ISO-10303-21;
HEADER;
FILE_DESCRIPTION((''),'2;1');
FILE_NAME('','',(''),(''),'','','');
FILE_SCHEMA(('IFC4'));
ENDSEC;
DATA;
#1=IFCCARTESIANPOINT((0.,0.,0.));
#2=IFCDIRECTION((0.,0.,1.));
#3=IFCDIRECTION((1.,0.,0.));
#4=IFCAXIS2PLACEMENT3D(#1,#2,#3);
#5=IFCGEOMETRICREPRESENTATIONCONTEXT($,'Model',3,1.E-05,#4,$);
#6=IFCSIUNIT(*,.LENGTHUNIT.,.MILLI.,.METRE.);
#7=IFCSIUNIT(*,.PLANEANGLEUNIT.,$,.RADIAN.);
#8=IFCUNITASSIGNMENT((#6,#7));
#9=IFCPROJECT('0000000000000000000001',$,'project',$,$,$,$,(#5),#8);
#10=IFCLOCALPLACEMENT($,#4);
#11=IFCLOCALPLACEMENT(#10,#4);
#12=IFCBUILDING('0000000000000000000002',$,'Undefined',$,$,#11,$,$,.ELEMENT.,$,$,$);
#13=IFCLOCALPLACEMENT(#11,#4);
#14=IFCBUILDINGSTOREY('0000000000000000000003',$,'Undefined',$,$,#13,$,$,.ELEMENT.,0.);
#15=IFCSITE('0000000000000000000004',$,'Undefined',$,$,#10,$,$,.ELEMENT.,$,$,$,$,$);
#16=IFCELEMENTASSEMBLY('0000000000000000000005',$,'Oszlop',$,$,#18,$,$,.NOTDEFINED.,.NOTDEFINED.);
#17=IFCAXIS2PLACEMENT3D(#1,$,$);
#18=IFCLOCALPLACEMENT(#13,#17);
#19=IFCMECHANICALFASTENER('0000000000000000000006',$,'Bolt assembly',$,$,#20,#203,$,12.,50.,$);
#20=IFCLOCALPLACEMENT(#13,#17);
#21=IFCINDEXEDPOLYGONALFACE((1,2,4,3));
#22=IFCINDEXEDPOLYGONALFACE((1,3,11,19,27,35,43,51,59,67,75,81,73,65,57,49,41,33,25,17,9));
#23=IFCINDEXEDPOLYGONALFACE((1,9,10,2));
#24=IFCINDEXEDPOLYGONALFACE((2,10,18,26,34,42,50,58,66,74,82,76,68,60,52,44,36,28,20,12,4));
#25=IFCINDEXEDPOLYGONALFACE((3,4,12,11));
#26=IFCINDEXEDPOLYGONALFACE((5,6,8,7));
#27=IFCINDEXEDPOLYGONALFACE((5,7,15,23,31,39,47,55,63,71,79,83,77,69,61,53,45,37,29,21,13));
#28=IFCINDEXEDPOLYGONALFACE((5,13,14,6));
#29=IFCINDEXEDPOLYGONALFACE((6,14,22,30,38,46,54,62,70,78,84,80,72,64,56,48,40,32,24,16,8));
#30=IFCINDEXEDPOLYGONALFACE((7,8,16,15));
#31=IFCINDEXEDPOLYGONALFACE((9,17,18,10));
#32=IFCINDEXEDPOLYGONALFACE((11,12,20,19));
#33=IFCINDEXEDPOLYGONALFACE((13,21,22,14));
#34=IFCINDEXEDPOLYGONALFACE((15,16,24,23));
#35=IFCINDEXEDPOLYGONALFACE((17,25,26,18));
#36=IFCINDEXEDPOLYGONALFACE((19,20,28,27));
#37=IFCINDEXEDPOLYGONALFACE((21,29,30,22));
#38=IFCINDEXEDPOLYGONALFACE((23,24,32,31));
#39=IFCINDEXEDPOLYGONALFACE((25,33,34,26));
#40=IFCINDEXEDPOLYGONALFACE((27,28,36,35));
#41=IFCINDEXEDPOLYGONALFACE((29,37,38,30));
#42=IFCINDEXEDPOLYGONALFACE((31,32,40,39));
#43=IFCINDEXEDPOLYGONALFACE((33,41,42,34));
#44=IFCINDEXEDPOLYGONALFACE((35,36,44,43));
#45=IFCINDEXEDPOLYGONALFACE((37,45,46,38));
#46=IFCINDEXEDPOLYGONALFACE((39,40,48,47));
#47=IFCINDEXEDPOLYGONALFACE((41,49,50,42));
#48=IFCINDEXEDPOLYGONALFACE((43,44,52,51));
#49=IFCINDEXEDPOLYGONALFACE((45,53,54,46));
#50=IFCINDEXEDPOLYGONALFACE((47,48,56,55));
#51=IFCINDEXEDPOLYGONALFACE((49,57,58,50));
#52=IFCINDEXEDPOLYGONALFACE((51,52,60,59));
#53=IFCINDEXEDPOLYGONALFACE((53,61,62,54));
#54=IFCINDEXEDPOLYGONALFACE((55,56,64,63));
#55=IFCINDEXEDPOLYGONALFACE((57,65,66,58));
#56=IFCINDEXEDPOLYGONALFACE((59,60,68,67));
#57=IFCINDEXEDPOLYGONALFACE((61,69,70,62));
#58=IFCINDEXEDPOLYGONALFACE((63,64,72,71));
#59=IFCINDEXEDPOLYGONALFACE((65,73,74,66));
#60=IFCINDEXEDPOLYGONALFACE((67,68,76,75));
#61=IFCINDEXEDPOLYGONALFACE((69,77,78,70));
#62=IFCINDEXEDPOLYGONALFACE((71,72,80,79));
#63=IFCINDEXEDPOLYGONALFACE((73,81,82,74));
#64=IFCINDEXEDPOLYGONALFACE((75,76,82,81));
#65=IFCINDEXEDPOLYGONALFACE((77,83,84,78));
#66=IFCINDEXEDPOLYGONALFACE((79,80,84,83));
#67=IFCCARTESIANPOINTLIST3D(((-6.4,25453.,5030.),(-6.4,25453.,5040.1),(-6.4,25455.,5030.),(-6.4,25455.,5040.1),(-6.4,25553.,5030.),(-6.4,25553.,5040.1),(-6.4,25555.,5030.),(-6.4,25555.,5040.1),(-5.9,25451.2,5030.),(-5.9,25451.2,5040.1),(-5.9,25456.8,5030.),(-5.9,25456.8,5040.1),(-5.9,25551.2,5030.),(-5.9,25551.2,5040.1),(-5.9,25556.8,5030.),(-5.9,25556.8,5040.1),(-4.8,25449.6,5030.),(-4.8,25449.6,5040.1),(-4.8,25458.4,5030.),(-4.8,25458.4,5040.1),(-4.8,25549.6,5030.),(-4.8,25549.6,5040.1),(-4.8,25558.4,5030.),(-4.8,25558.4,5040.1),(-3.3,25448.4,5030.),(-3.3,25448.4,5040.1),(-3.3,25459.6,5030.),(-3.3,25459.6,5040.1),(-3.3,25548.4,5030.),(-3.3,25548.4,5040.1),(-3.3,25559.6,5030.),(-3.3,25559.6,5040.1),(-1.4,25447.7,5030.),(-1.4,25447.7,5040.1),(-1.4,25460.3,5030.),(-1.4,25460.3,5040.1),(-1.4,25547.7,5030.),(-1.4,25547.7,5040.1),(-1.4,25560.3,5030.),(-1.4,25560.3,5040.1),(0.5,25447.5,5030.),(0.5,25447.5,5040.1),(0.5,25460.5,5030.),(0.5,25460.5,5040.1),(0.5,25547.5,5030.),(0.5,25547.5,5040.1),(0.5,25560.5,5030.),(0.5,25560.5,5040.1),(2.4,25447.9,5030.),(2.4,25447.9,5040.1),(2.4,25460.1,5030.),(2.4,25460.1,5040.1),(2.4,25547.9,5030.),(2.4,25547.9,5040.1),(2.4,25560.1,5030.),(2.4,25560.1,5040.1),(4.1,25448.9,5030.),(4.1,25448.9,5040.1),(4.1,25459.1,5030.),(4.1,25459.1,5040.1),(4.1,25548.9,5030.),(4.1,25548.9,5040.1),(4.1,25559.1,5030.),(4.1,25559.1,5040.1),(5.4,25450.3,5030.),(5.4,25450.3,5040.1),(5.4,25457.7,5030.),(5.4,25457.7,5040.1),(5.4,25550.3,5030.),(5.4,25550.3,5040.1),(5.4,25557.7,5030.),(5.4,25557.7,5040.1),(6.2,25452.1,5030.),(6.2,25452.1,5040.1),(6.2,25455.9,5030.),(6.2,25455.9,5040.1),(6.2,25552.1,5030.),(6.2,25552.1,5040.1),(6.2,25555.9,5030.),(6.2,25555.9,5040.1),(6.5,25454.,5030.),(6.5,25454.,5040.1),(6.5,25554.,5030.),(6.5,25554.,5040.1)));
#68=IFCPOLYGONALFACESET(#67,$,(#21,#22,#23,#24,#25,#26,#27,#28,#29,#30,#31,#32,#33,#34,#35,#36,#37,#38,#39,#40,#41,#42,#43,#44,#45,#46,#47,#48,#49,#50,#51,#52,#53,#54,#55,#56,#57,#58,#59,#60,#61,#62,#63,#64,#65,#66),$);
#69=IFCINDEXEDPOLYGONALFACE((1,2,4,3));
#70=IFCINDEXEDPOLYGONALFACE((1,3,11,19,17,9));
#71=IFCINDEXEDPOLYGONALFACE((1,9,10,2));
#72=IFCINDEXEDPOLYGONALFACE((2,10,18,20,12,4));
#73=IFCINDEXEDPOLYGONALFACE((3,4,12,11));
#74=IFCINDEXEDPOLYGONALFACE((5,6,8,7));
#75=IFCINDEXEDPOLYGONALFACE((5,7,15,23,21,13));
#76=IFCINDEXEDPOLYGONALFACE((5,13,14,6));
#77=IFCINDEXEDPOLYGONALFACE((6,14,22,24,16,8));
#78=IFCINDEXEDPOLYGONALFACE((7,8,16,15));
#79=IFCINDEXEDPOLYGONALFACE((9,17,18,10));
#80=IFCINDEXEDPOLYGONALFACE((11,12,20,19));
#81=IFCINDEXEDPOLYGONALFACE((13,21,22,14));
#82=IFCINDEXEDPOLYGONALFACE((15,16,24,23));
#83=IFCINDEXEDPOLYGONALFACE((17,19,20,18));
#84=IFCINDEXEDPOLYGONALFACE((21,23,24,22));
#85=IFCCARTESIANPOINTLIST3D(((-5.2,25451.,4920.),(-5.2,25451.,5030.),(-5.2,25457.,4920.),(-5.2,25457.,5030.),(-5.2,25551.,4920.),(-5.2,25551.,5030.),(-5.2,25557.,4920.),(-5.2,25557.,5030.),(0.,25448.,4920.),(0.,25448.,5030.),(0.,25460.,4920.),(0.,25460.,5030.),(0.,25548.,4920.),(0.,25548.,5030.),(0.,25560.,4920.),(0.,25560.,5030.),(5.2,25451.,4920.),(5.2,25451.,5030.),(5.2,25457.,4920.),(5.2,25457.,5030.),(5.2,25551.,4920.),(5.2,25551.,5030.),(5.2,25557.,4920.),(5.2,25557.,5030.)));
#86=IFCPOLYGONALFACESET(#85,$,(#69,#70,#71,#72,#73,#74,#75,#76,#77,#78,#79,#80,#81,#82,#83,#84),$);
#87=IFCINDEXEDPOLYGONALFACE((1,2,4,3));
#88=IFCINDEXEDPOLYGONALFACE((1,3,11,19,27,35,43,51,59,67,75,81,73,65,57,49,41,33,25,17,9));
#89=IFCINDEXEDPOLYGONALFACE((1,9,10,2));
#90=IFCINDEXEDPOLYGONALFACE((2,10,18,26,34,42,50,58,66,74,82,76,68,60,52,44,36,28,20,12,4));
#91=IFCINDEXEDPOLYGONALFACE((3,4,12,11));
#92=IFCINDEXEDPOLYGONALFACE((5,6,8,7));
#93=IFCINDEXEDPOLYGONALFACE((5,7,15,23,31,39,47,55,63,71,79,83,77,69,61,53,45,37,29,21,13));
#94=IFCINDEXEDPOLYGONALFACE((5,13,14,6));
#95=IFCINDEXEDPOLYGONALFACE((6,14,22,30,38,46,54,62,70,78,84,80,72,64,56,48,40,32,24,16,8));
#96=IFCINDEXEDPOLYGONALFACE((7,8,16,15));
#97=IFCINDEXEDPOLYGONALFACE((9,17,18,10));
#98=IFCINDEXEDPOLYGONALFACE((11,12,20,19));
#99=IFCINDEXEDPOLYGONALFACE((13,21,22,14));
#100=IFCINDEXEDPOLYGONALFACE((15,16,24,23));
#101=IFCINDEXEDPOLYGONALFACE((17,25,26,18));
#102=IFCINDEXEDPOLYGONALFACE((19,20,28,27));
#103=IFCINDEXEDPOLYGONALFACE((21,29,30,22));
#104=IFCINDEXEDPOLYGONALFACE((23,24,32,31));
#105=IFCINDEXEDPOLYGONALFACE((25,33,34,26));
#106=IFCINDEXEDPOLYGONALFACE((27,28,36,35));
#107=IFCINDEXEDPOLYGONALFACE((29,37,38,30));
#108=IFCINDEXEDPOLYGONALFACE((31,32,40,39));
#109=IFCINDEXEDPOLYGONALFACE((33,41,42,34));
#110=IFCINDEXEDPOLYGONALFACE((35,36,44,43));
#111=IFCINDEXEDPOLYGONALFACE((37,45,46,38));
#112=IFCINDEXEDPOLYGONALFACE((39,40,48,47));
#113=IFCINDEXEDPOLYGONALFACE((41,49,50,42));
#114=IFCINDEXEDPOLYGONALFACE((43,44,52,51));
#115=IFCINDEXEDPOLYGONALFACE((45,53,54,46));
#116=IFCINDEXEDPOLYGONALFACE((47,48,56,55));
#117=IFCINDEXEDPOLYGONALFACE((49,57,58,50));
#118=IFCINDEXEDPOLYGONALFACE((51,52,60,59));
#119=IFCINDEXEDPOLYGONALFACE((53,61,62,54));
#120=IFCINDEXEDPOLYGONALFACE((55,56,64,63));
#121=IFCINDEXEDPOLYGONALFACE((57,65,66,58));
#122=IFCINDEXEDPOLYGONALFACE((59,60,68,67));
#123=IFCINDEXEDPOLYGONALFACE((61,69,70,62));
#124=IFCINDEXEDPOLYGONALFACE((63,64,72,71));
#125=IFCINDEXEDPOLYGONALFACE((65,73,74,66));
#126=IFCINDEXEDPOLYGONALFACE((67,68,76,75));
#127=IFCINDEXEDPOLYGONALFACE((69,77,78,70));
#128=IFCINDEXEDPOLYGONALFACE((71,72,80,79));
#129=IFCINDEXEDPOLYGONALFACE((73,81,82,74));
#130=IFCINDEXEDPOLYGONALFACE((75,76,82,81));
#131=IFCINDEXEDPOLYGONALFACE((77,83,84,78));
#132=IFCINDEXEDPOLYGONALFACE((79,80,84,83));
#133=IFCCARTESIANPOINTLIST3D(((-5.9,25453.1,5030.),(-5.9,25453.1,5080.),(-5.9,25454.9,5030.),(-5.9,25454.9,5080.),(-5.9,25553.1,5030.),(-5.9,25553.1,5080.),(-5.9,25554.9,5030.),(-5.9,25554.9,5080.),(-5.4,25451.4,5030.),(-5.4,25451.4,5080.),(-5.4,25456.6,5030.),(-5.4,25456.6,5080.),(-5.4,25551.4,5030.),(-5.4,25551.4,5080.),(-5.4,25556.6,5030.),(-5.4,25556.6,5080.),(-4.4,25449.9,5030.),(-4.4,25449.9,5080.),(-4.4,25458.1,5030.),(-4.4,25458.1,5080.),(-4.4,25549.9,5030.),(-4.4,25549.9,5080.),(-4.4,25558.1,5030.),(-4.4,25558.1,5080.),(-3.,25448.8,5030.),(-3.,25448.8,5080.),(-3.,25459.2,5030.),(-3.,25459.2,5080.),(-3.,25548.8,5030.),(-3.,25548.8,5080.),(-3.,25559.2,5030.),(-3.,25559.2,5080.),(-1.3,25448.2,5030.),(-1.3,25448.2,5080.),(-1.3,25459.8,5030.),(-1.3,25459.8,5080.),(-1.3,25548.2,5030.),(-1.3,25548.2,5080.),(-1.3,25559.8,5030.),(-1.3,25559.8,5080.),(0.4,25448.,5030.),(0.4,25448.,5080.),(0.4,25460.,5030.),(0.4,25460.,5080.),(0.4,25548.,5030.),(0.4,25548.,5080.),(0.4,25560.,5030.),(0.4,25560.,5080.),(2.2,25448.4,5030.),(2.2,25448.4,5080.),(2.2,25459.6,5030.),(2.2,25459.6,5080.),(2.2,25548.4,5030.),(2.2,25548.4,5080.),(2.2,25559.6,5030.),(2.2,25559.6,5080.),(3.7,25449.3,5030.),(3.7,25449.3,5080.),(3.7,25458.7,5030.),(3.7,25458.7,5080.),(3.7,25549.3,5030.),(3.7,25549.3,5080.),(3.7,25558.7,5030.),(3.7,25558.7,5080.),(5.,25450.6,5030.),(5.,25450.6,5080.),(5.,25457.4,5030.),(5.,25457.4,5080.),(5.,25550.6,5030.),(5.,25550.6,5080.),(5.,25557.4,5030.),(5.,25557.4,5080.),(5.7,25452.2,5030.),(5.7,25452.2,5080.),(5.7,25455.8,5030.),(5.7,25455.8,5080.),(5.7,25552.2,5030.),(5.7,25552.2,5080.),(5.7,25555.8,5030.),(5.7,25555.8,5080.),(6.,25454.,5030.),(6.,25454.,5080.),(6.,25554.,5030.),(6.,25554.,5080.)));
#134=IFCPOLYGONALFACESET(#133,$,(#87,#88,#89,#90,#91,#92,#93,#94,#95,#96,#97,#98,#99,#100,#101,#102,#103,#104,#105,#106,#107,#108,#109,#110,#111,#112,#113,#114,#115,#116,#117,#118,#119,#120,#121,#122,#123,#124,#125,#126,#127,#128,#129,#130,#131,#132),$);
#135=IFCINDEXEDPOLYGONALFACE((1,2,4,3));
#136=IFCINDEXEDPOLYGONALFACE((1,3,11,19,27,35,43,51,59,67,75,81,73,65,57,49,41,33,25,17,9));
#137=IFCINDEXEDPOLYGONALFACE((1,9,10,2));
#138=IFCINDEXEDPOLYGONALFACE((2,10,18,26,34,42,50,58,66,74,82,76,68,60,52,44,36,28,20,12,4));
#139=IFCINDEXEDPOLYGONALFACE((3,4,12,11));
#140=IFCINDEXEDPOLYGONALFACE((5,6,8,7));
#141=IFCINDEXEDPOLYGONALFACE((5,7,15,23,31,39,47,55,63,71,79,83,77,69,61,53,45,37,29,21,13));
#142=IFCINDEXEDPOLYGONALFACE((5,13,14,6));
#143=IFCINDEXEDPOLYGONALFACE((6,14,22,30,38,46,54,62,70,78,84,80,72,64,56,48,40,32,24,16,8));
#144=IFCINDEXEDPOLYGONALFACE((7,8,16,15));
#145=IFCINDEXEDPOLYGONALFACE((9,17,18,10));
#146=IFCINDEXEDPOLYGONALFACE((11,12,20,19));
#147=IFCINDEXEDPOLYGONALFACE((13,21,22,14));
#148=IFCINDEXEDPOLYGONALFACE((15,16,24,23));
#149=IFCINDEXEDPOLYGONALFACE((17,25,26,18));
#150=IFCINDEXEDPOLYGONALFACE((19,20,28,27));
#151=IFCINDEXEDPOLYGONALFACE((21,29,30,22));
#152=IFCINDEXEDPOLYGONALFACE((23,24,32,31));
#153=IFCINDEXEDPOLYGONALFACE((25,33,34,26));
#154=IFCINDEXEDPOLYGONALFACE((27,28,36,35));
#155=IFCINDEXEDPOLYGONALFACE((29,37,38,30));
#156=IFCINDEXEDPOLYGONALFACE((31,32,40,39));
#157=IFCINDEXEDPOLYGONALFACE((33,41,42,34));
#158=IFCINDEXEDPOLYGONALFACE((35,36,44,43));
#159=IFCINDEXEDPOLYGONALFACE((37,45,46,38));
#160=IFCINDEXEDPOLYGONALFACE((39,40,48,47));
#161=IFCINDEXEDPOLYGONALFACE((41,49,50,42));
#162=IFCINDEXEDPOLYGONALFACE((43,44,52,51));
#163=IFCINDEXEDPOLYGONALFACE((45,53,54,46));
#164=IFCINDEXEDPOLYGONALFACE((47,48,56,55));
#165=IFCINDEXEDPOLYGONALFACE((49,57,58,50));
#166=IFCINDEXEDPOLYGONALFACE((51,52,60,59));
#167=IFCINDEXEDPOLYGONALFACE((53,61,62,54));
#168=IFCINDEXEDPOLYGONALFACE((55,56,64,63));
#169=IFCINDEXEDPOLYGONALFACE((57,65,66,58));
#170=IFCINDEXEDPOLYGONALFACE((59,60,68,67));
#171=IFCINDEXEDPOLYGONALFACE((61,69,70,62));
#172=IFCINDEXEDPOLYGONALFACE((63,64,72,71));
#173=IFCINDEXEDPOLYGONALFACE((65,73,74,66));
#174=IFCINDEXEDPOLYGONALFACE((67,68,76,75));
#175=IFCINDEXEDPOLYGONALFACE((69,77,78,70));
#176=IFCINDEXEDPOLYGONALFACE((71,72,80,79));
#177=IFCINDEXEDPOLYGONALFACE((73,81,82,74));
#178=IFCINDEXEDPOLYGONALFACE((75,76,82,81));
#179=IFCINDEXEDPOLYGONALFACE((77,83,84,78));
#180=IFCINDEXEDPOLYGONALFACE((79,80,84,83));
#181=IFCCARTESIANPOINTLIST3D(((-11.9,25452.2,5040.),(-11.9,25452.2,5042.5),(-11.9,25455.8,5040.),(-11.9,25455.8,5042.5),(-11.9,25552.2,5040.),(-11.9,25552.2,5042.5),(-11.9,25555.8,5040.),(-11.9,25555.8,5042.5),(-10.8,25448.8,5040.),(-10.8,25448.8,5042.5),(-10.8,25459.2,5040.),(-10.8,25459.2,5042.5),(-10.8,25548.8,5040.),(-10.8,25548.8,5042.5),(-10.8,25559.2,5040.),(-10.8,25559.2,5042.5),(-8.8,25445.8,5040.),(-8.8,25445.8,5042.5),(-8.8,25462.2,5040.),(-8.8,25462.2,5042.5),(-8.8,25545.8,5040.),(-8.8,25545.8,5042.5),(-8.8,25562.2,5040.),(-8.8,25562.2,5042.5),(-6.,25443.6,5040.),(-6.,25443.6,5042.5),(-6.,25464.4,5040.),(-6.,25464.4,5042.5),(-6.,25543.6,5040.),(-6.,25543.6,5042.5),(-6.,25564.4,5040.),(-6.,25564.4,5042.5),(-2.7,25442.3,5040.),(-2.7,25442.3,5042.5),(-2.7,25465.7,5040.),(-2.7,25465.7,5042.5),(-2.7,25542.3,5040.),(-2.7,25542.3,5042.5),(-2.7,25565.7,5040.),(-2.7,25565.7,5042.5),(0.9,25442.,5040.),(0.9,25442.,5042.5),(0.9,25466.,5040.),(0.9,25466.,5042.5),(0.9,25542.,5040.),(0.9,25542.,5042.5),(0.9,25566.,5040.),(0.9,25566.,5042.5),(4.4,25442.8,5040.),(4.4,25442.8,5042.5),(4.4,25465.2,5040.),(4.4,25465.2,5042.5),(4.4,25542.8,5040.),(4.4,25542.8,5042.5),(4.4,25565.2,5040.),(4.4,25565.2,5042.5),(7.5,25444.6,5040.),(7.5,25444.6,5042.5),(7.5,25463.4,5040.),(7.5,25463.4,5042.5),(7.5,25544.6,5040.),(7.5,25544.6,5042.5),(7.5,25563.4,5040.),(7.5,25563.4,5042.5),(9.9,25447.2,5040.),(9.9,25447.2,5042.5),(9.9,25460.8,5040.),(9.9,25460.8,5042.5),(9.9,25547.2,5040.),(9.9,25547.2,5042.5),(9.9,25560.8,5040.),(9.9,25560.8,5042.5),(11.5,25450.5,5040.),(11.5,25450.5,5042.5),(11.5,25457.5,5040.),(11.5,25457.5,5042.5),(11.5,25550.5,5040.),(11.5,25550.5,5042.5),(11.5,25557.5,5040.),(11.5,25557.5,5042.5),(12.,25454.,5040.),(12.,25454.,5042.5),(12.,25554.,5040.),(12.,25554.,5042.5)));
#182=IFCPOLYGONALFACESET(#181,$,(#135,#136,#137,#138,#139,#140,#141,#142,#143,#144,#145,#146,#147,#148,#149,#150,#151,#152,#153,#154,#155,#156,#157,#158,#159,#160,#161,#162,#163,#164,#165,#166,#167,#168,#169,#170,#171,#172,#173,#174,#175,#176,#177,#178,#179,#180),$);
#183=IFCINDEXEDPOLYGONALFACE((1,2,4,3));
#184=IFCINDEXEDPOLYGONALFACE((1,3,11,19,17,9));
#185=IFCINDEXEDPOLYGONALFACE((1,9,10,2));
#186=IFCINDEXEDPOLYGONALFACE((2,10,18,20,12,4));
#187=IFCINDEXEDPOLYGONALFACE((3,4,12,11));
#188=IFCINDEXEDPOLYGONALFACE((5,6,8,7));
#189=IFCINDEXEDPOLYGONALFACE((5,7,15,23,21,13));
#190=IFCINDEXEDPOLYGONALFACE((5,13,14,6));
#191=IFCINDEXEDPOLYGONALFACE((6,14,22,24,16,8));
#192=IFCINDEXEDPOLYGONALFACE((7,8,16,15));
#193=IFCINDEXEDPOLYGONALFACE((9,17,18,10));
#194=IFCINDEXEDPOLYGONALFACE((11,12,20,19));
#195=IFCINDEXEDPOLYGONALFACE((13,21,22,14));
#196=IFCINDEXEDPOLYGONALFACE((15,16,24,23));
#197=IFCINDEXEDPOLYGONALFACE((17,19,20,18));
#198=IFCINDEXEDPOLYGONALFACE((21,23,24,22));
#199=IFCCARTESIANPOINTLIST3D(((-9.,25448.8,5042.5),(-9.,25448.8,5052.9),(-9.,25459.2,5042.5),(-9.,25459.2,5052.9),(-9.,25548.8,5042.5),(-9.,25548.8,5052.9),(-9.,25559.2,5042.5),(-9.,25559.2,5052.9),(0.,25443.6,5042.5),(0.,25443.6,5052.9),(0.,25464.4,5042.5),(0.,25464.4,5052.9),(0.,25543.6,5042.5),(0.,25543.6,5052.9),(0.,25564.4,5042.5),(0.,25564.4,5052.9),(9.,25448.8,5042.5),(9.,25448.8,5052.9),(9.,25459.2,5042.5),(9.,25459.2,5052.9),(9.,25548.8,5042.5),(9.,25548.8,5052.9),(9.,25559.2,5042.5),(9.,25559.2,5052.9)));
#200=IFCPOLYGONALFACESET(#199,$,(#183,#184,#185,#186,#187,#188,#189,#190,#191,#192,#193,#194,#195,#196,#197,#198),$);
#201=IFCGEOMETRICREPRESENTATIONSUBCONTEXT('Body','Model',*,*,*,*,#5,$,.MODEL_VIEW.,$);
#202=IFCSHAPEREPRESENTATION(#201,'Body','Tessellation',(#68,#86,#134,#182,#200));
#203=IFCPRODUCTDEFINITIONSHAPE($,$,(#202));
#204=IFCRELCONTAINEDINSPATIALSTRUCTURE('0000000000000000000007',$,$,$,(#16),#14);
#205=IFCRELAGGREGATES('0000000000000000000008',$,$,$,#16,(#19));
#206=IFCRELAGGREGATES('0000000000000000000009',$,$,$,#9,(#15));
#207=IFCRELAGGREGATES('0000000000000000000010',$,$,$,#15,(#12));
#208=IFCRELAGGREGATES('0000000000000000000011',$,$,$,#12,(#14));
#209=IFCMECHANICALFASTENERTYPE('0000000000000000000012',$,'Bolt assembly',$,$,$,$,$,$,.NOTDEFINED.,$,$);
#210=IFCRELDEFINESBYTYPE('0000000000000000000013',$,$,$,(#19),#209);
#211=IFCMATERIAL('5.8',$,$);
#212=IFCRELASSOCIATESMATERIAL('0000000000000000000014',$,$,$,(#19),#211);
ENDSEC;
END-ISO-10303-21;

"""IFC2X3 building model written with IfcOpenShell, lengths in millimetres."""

from ifc_helpers import new_model, si_unit, frame, origin_with_axes, origin_2d_with_axis, place, context, subcontext, project, spatial, polyline, circle, outline, extrude, source, transform, mapped, material, type_object, element, aggregate, save


model = new_model("IFC2X3")

# Units and contexts
model_context = context("Model", 3, precision=1e-05, world=origin_with_axes())
body_context = subcontext(model_context, "Body", "Model", "MODEL_VIEW")
ifc_project = project(units=[si_unit("LENGTHUNIT", "METRE", prefix="MILLI"), si_unit("PLANEANGLEUNIT", "RADIAN")], contexts=[model_context])

# Site, building, storey
site_placement = place(None, origin_with_axes())
site = spatial("IfcSite", under=ifc_project, at=site_placement, Name="Undefined", CompositionType="ELEMENT")
building_placement = place(site_placement, origin_with_axes())
building = spatial("IfcBuilding", under=site, at=building_placement, Name="Undefined", CompositionType="ELEMENT")
storey_placement = place(building_placement, origin_with_axes())
storey = spatial("IfcBuildingStorey", under=building, at=storey_placement, Name="Undefined", CompositionType="ELEMENT", Elevation=0.0)

# Element assembly
assembly_1_placement = place(storey_placement, origin_with_axes())
assembly_1 = element("IfcElementAssembly", 1, at=assembly_1_placement, inside=storey, Name="Oszlop", AssemblyPlace="NOTDEFINED", PredefinedType="NOTDEFINED")

# Mechanical fastener
mechanical_fastener_type = type_object("IfcMechanicalFastenerType", Name="Bolt assembly")
ifc_material_1 = material(Name="5.8")
shared_shape_1 = source(origin_with_axes(), body_context, "Body", "SweptSolid", [
    extrude(circle(Radius=6.5, at=origin_2d_with_axis()), frame((0.0, -10.0, 0.0), z_axis=(0.0, 1.0, 0.0), x_axis=(1.0, 0.0, 0.0)), (0.0, 0.0, 1.0), 10.1),
    extrude(outline(polyline([(5.2, -3.0), (5.2, 3.0), (0.0, 6.0), (-5.2, 3.0), (-5.2, -3.0), (0.0, -6.0), (5.2, -3.0)])), frame((0.0, -120.0, 0.0), z_axis=(0.0, 1.0, 0.0), x_axis=(1.0, 0.0, 0.0)), (0.0, 0.0, 1.0), 110.0),
    extrude(circle(Radius=6.0, at=origin_2d_with_axis()), frame((0.0, -10.0, 0.0), z_axis=(0.0, 1.0, 0.0), x_axis=(1.0, 0.0, 0.0)), (0.0, 0.0, 1.0), 50.0),
    extrude(circle(Radius=12.0, at=origin_2d_with_axis()), frame((0.0, 0.0, 0.0), z_axis=(0.0, 1.0, 0.0), x_axis=(1.0, 0.0, 0.0)), (0.0, 0.0, 1.0), 2.5),
    extrude(outline(polyline([(9.0, -5.2), (9.0, 5.2), (0.0, 10.4), (-9.0, 5.2), (-9.0, -5.2), (0.0, -10.4), (9.0, -5.2)])), frame((0.0, 2.5, 0.0), z_axis=(0.0, 1.0, 0.0), x_axis=(1.0, 0.0, 0.0)), (0.0, 0.0, 1.0), 10.4),
])
mechanical_fastener_1_placement = place(assembly_1_placement, frame((-48.0, 25504.0, 5040.0), z_axis=(0.0, -1.0, 0.0), x_axis=(1.0, 0.0, 0.0)))
mechanical_fastener_1 = element("IfcMechanicalFastener", 2, at=mechanical_fastener_1_placement, type_object=mechanical_fastener_type, material=ifc_material_1, Name="Bolt assembly", NominalDiameter=12.0, NominalLength=50.0, context=body_context, shape_type="MappedRepresentation", body=[
    mapped(shared_shape_1, transform((48.0, 0.0, -50.0))),
    mapped(shared_shape_1, transform((48.0, 0.0, 50.0))),
])
aggregate(assembly_1, [mechanical_fastener_1])

save(model, "model.ifc")
